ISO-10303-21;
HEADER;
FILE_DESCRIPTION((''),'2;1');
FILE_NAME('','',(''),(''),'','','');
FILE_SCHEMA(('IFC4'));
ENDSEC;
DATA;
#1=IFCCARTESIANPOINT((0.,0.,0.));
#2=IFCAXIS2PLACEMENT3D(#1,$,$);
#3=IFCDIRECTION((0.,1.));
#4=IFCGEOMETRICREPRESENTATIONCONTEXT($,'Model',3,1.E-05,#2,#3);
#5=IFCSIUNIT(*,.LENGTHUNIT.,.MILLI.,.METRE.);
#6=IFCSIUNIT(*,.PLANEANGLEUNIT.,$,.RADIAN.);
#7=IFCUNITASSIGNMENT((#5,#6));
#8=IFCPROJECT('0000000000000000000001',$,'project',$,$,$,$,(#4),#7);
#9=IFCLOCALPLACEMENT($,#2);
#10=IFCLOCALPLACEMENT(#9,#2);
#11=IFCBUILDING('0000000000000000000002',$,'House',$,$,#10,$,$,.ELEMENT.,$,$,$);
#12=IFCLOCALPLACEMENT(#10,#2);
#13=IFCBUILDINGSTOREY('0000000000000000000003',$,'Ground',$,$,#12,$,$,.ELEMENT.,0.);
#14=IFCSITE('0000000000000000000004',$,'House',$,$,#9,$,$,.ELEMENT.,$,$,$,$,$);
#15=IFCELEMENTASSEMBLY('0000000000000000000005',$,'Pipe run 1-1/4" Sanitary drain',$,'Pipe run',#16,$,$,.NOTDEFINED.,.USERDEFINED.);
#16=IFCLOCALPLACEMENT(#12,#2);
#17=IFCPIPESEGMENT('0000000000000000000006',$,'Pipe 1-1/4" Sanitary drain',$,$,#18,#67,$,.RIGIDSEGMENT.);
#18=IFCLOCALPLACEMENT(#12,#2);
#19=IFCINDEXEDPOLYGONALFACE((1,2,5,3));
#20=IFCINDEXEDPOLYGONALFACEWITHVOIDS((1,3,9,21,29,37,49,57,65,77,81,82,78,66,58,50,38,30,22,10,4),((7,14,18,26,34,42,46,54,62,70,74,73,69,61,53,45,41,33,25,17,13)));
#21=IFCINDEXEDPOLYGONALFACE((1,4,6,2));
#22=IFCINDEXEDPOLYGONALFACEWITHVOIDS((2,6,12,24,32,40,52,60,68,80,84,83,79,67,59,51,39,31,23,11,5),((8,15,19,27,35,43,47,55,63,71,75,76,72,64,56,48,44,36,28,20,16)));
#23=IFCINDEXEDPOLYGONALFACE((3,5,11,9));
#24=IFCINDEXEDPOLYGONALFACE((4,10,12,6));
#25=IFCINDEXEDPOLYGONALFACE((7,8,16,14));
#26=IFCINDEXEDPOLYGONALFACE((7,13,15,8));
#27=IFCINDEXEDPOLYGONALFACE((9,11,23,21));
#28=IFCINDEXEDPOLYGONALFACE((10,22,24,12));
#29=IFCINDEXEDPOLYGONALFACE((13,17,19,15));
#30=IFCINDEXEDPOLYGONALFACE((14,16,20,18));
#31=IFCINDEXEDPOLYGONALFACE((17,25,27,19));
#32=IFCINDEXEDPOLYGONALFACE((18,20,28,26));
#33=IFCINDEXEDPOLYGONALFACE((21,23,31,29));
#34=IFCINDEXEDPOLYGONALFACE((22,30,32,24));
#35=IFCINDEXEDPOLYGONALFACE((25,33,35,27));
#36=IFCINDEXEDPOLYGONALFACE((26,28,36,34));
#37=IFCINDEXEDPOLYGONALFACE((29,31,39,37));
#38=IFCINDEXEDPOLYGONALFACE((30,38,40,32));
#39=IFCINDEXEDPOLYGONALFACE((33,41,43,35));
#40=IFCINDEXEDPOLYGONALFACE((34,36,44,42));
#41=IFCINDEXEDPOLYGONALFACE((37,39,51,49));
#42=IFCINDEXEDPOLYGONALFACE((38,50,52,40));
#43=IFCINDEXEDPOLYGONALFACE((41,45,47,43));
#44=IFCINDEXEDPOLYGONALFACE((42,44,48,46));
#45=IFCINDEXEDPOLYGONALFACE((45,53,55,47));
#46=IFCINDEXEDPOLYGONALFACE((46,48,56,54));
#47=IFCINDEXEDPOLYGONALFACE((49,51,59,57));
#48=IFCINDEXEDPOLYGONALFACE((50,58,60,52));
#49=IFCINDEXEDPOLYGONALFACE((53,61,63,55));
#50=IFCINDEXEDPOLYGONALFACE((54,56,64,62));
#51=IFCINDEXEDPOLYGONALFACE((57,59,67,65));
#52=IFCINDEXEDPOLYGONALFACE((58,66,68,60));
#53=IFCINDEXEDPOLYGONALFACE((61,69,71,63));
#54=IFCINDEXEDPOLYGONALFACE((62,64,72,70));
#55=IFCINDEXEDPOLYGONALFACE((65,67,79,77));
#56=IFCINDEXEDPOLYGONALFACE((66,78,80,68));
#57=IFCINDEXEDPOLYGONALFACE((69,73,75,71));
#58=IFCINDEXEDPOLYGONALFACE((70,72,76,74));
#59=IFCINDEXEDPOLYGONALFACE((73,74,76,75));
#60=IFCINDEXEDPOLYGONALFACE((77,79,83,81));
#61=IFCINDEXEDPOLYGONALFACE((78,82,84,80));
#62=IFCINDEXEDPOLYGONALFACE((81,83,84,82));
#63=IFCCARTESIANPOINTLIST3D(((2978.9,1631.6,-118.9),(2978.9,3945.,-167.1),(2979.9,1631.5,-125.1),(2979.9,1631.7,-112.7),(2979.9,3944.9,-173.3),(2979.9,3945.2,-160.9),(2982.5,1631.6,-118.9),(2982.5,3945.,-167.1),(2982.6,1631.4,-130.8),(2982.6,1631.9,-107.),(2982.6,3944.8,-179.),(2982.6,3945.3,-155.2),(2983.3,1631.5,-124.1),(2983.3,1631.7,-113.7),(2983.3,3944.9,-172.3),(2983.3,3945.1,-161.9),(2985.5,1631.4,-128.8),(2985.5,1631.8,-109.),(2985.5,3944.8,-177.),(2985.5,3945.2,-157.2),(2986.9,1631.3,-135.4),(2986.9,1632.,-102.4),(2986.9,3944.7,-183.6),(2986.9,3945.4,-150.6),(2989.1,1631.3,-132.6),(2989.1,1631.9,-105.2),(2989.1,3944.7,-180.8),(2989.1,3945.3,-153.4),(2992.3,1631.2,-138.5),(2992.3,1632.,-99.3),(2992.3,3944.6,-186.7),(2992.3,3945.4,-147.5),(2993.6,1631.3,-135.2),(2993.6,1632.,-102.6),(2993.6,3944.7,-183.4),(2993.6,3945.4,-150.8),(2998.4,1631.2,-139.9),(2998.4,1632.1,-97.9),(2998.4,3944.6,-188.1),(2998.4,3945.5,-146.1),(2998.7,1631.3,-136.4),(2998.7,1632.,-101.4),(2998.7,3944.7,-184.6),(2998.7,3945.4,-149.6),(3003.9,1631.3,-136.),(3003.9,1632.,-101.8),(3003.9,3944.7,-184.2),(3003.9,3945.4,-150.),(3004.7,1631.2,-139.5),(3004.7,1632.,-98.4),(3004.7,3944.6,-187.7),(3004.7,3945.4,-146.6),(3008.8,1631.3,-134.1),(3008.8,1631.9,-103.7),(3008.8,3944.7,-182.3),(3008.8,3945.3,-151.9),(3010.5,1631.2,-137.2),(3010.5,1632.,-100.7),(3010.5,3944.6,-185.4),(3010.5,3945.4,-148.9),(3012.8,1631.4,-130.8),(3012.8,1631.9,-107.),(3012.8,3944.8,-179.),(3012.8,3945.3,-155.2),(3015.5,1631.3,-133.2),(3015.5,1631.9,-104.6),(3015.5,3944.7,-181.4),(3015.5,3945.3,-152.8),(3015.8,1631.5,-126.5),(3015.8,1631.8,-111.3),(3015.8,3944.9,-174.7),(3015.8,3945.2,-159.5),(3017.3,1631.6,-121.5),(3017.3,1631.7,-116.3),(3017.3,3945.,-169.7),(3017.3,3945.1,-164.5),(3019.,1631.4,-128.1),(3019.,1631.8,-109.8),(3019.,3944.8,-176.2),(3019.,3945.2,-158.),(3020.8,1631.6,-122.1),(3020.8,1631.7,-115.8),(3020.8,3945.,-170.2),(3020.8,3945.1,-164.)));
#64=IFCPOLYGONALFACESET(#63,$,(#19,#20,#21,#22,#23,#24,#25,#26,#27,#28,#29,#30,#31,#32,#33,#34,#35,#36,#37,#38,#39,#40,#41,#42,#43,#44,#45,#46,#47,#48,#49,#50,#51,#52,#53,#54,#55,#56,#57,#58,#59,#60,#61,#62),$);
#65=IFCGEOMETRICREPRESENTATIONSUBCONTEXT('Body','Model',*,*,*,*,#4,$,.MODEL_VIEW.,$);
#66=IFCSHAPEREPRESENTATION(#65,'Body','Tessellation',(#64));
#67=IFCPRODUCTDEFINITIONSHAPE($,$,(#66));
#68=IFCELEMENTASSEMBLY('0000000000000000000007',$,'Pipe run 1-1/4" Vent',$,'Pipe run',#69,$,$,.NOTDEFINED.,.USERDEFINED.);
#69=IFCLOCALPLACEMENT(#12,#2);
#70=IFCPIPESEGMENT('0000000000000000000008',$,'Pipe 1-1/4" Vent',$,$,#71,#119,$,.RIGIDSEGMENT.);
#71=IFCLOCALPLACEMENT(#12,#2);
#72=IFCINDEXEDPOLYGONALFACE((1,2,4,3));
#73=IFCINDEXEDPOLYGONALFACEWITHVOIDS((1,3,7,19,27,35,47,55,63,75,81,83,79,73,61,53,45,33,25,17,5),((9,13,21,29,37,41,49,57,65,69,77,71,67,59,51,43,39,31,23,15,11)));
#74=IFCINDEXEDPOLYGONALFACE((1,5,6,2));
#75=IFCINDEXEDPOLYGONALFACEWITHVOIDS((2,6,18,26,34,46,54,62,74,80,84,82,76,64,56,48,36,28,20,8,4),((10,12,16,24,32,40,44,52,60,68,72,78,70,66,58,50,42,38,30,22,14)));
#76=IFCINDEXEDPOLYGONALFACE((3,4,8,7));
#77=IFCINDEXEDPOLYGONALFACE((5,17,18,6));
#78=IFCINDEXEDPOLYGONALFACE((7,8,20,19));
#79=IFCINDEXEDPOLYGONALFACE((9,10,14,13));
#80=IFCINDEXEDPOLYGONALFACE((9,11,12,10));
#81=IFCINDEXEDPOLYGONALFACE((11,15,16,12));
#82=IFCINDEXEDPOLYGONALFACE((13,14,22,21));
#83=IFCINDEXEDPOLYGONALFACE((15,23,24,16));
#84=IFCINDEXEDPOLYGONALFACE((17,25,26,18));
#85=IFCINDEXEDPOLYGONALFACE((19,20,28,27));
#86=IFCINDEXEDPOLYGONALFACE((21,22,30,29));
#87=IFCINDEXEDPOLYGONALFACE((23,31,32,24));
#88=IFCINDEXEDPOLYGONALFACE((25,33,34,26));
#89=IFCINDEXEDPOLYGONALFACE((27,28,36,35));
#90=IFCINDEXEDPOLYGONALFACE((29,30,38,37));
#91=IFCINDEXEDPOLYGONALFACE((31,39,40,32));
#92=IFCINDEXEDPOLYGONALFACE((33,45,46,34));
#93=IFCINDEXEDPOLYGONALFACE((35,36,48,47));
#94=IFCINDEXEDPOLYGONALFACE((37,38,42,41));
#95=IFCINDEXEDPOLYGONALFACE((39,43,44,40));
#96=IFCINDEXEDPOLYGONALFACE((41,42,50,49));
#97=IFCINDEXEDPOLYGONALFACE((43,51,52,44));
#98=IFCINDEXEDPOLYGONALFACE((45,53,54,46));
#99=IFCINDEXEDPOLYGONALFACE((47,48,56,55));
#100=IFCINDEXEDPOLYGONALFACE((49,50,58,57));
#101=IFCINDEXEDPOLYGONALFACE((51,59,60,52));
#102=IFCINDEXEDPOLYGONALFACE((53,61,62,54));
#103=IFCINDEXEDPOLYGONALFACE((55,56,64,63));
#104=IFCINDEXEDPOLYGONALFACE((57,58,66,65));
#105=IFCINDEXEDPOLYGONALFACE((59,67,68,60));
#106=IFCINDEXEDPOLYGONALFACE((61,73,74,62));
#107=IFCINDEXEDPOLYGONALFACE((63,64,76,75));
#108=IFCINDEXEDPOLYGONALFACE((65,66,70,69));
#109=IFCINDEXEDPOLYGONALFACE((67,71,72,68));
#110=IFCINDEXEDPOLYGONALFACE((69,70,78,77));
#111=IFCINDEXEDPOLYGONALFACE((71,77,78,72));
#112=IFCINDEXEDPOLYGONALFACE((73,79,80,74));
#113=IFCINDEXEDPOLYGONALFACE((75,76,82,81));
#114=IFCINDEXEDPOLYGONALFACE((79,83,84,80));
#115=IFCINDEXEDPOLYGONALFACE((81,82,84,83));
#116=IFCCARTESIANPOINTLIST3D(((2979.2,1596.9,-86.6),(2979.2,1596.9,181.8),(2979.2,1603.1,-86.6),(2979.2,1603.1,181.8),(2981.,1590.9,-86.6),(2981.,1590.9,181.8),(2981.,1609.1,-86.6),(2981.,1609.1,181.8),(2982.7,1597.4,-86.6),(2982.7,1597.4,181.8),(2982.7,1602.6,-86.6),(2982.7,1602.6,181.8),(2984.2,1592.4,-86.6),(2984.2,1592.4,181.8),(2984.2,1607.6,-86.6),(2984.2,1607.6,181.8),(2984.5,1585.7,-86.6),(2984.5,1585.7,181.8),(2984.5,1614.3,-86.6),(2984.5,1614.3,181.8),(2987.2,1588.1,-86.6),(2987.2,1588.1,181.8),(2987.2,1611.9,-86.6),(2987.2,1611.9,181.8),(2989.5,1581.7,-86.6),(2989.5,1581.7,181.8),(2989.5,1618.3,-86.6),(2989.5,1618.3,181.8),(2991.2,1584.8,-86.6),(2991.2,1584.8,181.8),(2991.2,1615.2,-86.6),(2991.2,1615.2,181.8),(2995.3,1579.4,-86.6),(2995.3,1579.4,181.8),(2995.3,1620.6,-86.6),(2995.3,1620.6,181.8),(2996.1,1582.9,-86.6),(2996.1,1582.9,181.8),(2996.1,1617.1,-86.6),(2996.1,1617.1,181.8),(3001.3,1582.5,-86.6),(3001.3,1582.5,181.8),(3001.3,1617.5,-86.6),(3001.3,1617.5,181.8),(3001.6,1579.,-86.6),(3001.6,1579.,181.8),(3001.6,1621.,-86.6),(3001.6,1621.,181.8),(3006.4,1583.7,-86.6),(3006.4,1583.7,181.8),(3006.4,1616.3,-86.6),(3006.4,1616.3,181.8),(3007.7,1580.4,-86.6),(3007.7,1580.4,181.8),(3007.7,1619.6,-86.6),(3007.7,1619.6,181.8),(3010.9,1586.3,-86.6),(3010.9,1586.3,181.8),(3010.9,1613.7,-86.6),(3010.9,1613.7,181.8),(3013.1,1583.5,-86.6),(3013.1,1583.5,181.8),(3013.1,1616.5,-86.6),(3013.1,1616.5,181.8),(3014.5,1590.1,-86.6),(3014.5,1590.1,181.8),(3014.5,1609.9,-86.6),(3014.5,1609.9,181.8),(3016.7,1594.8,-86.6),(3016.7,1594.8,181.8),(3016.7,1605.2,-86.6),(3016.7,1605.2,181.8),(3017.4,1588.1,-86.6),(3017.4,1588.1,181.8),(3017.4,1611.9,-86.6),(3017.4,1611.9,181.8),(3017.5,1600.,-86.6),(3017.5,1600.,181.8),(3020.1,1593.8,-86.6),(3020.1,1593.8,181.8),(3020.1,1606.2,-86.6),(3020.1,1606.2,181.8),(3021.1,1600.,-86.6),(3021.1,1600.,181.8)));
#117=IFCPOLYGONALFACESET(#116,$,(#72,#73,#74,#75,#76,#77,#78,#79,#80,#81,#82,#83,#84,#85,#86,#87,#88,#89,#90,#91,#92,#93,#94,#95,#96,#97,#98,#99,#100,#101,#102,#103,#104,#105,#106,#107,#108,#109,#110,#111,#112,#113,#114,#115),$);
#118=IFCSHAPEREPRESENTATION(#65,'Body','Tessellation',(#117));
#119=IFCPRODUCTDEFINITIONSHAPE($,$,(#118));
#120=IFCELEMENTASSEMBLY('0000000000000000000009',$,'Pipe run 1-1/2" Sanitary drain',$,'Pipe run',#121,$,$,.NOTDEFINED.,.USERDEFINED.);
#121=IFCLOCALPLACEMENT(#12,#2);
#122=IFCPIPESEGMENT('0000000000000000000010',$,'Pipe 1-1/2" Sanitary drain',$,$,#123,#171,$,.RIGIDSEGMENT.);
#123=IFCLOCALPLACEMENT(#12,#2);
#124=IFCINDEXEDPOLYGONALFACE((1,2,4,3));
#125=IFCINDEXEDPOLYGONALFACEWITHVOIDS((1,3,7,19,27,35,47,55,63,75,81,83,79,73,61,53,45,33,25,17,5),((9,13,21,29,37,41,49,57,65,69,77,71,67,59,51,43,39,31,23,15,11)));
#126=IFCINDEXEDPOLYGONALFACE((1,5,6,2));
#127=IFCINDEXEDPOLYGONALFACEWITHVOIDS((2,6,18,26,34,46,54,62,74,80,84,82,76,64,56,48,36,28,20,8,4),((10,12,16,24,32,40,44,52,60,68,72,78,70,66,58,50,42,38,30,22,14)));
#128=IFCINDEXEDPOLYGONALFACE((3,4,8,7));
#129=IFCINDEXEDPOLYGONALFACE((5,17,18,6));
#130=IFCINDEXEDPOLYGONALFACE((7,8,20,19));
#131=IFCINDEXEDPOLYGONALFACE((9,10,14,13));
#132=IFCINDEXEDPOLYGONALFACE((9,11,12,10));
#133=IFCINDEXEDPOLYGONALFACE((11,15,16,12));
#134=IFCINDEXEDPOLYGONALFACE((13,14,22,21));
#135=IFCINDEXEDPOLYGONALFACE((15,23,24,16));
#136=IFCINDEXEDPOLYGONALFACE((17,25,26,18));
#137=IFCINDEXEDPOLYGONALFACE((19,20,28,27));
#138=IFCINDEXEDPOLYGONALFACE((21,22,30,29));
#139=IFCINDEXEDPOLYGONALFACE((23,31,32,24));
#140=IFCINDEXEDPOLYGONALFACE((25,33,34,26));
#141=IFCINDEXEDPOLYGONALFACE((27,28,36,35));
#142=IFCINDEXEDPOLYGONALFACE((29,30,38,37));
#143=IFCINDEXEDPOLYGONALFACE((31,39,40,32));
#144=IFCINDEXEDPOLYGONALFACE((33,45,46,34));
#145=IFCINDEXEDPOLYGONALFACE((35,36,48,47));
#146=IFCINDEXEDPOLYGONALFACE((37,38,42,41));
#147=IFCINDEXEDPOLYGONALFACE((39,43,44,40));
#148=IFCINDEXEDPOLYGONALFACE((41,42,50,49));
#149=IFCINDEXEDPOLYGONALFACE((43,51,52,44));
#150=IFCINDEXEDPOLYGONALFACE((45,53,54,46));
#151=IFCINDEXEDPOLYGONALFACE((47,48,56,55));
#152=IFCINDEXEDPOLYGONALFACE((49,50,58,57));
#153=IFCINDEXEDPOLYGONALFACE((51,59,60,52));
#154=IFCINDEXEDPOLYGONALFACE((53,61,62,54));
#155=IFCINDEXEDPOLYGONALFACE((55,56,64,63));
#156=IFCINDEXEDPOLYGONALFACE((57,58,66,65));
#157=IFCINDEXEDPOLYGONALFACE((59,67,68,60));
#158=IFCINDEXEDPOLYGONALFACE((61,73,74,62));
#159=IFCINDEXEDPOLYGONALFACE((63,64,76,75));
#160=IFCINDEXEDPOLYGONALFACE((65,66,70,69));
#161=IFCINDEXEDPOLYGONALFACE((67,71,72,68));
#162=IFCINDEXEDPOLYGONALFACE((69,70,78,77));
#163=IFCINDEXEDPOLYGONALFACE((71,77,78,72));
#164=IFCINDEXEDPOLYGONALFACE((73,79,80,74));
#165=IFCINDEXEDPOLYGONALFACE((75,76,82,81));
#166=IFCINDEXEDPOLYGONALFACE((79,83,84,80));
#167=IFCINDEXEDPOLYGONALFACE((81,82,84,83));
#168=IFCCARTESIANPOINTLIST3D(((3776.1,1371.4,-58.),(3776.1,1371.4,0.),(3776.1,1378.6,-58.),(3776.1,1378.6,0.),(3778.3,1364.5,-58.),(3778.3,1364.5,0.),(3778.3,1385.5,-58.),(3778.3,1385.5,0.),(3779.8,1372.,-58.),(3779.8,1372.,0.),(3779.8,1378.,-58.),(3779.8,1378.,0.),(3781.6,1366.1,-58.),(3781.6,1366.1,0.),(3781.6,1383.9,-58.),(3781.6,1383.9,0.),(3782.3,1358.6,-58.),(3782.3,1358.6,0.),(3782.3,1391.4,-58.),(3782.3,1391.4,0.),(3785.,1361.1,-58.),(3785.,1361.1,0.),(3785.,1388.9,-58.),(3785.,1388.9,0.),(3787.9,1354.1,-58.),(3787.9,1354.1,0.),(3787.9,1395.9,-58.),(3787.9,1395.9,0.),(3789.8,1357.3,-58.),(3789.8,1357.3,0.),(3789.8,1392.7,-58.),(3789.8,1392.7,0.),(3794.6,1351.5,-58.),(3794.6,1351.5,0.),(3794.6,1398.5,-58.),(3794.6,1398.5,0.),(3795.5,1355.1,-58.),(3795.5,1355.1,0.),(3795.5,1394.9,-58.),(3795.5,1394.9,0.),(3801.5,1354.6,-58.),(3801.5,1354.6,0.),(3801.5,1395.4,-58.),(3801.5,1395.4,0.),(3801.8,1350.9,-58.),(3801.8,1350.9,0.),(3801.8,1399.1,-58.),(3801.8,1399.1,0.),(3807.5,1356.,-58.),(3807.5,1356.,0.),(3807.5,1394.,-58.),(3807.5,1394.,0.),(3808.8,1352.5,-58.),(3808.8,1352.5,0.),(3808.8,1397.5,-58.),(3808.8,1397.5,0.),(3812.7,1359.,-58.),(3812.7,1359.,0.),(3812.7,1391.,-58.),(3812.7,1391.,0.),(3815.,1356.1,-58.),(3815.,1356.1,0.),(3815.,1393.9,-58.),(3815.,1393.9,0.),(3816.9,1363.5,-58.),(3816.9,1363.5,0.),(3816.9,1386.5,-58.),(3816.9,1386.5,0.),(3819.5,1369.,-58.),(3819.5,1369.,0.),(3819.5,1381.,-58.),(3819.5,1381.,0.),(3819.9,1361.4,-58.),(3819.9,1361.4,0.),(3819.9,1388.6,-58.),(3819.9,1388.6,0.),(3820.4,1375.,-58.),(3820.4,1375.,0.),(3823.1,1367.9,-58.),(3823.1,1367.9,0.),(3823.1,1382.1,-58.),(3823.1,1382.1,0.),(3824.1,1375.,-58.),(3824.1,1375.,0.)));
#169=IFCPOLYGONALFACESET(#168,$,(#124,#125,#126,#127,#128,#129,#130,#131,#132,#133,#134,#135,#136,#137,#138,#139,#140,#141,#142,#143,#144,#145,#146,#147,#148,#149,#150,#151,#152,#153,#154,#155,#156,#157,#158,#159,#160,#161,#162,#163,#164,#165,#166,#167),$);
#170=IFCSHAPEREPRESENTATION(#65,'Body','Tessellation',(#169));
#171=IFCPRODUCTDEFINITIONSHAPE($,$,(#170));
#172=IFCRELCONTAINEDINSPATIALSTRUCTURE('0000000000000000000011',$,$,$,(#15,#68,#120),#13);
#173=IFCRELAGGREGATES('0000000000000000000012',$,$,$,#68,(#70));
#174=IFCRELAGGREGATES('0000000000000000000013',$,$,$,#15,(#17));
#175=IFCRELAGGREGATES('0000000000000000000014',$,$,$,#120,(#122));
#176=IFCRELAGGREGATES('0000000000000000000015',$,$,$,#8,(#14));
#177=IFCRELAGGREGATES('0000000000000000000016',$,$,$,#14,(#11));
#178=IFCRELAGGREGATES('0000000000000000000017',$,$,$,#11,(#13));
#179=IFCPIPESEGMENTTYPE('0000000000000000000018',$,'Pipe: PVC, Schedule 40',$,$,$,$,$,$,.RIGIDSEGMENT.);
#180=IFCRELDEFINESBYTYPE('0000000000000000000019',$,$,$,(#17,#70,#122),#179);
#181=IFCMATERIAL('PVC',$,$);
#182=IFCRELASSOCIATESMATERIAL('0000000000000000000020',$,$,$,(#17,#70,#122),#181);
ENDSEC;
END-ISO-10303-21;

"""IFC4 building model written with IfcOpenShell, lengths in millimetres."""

from ifc_helpers import new_model, si_unit, direction, frame, origin, origin_with_axes, origin_2d, place, context, subcontext, project, spatial, hollow_circle, extrude, material, type_object, element, aggregate, save


model = new_model("IFC4")

# Units and contexts
model_context = context("Model", 3, precision=1e-05, world=origin(), true_north=direction((0.0, 1.0)))
body_context = subcontext(model_context, "Body", "Model", "MODEL_VIEW")
ifc_project = project(units=[si_unit("LENGTHUNIT", "METRE", prefix="MILLI"), si_unit("PLANEANGLEUNIT", "RADIAN")], contexts=[model_context])

# Site, building, storey
site_placement = place(None, origin())
site = spatial("IfcSite", under=ifc_project, at=site_placement, Name="House", CompositionType="ELEMENT")
building_placement = place(site_placement, origin())
building = spatial("IfcBuilding", under=site, at=building_placement, Name="House", CompositionType="ELEMENT")
storey_placement = place(building_placement, origin())
storey = spatial("IfcBuildingStorey", under=building, at=storey_placement, Name="Ground", CompositionType="ELEMENT", Elevation=0.0)

# Shared definitions
ifc_material = material(Name="PVC")
pipe_segment_type = type_object("IfcPipeSegmentType", Name="Pipe: PVC, Schedule 40", PredefinedType="RIGIDSEGMENT")

# Element assembly, pipe segment
assembly_1_placement = place(storey_placement, origin_with_axes())
assembly_1 = element("IfcElementAssembly", 1, at=assembly_1_placement, inside=storey, Name="Pipe run 1-1/4\" Sanitary drain", ObjectType="Pipe run", AssemblyPlace="NOTDEFINED", PredefinedType="USERDEFINED")
pipe_segment_1_placement = place(storey_placement, origin_with_axes())
pipe_segment_1 = element("IfcPipeSegment", 2, at=pipe_segment_1_placement, type_object=pipe_segment_type, material=ifc_material, Name="Pipe 1-1/4\" Sanitary drain", PredefinedType="RIGIDSEGMENT", context=body_context, shape_type="SweptSolid", body=[
    extrude(hollow_circle(Radius=21.1, WallThickness=3.6, at=origin_2d()), frame((3000.0, 1631.6, -118.9), z_axis=(0.0, 0.999783, -0.020829), x_axis=(-1.0, 0.0, 0.0)), (0.0, 0.0, 1.0), 2313.9),
])

# Element assembly, pipe segment
assembly_2_placement = place(storey_placement, origin_with_axes())
assembly_2 = element("IfcElementAssembly", 3, at=assembly_2_placement, inside=storey, Name="Pipe run 1-1/4\" Vent", ObjectType="Pipe run", AssemblyPlace="NOTDEFINED", PredefinedType="USERDEFINED")
pipe_segment_2_placement = place(storey_placement, origin_with_axes())
pipe_segment_2 = element("IfcPipeSegment", 4, at=pipe_segment_2_placement, type_object=pipe_segment_type, material=ifc_material, Name="Pipe 1-1/4\" Vent", PredefinedType="RIGIDSEGMENT", context=body_context, shape_type="SweptSolid", body=[
    extrude(hollow_circle(Radius=21.1, WallThickness=3.6, at=origin_2d()), frame((3000.0, 1600.0, 181.8), z_axis=(0.0, 0.0, -1.0), x_axis=(1.0, 0.0, 0.0)), (0.0, 0.0, 1.0), 268.4),
])
aggregate(assembly_2, [pipe_segment_2])

# Element assembly, pipe segment
assembly_3_placement = place(storey_placement, origin_with_axes())
assembly_3 = element("IfcElementAssembly", 5, at=assembly_3_placement, inside=storey, Name="Pipe run 1-1/2\" Sanitary drain", ObjectType="Pipe run", AssemblyPlace="NOTDEFINED", PredefinedType="USERDEFINED")
pipe_segment_3_placement = place(storey_placement, origin_with_axes())
pipe_segment_3 = element("IfcPipeSegment", 6, at=pipe_segment_3_placement, type_object=pipe_segment_type, material=ifc_material, Name="Pipe 1-1/2\" Sanitary drain", PredefinedType="RIGIDSEGMENT", context=body_context, shape_type="SweptSolid", body=[
    extrude(hollow_circle(Radius=24.1, WallThickness=3.7, at=origin_2d()), frame((3800.0, 1375.0, 0.0), z_axis=(0.0, 0.0, -1.0), x_axis=(1.0, 0.0, 0.0)), (0.0, 0.0, 1.0), 58.0),
])

aggregate(assembly_1, [pipe_segment_1])
aggregate(assembly_3, [pipe_segment_3])

save(model, "model.ifc")
